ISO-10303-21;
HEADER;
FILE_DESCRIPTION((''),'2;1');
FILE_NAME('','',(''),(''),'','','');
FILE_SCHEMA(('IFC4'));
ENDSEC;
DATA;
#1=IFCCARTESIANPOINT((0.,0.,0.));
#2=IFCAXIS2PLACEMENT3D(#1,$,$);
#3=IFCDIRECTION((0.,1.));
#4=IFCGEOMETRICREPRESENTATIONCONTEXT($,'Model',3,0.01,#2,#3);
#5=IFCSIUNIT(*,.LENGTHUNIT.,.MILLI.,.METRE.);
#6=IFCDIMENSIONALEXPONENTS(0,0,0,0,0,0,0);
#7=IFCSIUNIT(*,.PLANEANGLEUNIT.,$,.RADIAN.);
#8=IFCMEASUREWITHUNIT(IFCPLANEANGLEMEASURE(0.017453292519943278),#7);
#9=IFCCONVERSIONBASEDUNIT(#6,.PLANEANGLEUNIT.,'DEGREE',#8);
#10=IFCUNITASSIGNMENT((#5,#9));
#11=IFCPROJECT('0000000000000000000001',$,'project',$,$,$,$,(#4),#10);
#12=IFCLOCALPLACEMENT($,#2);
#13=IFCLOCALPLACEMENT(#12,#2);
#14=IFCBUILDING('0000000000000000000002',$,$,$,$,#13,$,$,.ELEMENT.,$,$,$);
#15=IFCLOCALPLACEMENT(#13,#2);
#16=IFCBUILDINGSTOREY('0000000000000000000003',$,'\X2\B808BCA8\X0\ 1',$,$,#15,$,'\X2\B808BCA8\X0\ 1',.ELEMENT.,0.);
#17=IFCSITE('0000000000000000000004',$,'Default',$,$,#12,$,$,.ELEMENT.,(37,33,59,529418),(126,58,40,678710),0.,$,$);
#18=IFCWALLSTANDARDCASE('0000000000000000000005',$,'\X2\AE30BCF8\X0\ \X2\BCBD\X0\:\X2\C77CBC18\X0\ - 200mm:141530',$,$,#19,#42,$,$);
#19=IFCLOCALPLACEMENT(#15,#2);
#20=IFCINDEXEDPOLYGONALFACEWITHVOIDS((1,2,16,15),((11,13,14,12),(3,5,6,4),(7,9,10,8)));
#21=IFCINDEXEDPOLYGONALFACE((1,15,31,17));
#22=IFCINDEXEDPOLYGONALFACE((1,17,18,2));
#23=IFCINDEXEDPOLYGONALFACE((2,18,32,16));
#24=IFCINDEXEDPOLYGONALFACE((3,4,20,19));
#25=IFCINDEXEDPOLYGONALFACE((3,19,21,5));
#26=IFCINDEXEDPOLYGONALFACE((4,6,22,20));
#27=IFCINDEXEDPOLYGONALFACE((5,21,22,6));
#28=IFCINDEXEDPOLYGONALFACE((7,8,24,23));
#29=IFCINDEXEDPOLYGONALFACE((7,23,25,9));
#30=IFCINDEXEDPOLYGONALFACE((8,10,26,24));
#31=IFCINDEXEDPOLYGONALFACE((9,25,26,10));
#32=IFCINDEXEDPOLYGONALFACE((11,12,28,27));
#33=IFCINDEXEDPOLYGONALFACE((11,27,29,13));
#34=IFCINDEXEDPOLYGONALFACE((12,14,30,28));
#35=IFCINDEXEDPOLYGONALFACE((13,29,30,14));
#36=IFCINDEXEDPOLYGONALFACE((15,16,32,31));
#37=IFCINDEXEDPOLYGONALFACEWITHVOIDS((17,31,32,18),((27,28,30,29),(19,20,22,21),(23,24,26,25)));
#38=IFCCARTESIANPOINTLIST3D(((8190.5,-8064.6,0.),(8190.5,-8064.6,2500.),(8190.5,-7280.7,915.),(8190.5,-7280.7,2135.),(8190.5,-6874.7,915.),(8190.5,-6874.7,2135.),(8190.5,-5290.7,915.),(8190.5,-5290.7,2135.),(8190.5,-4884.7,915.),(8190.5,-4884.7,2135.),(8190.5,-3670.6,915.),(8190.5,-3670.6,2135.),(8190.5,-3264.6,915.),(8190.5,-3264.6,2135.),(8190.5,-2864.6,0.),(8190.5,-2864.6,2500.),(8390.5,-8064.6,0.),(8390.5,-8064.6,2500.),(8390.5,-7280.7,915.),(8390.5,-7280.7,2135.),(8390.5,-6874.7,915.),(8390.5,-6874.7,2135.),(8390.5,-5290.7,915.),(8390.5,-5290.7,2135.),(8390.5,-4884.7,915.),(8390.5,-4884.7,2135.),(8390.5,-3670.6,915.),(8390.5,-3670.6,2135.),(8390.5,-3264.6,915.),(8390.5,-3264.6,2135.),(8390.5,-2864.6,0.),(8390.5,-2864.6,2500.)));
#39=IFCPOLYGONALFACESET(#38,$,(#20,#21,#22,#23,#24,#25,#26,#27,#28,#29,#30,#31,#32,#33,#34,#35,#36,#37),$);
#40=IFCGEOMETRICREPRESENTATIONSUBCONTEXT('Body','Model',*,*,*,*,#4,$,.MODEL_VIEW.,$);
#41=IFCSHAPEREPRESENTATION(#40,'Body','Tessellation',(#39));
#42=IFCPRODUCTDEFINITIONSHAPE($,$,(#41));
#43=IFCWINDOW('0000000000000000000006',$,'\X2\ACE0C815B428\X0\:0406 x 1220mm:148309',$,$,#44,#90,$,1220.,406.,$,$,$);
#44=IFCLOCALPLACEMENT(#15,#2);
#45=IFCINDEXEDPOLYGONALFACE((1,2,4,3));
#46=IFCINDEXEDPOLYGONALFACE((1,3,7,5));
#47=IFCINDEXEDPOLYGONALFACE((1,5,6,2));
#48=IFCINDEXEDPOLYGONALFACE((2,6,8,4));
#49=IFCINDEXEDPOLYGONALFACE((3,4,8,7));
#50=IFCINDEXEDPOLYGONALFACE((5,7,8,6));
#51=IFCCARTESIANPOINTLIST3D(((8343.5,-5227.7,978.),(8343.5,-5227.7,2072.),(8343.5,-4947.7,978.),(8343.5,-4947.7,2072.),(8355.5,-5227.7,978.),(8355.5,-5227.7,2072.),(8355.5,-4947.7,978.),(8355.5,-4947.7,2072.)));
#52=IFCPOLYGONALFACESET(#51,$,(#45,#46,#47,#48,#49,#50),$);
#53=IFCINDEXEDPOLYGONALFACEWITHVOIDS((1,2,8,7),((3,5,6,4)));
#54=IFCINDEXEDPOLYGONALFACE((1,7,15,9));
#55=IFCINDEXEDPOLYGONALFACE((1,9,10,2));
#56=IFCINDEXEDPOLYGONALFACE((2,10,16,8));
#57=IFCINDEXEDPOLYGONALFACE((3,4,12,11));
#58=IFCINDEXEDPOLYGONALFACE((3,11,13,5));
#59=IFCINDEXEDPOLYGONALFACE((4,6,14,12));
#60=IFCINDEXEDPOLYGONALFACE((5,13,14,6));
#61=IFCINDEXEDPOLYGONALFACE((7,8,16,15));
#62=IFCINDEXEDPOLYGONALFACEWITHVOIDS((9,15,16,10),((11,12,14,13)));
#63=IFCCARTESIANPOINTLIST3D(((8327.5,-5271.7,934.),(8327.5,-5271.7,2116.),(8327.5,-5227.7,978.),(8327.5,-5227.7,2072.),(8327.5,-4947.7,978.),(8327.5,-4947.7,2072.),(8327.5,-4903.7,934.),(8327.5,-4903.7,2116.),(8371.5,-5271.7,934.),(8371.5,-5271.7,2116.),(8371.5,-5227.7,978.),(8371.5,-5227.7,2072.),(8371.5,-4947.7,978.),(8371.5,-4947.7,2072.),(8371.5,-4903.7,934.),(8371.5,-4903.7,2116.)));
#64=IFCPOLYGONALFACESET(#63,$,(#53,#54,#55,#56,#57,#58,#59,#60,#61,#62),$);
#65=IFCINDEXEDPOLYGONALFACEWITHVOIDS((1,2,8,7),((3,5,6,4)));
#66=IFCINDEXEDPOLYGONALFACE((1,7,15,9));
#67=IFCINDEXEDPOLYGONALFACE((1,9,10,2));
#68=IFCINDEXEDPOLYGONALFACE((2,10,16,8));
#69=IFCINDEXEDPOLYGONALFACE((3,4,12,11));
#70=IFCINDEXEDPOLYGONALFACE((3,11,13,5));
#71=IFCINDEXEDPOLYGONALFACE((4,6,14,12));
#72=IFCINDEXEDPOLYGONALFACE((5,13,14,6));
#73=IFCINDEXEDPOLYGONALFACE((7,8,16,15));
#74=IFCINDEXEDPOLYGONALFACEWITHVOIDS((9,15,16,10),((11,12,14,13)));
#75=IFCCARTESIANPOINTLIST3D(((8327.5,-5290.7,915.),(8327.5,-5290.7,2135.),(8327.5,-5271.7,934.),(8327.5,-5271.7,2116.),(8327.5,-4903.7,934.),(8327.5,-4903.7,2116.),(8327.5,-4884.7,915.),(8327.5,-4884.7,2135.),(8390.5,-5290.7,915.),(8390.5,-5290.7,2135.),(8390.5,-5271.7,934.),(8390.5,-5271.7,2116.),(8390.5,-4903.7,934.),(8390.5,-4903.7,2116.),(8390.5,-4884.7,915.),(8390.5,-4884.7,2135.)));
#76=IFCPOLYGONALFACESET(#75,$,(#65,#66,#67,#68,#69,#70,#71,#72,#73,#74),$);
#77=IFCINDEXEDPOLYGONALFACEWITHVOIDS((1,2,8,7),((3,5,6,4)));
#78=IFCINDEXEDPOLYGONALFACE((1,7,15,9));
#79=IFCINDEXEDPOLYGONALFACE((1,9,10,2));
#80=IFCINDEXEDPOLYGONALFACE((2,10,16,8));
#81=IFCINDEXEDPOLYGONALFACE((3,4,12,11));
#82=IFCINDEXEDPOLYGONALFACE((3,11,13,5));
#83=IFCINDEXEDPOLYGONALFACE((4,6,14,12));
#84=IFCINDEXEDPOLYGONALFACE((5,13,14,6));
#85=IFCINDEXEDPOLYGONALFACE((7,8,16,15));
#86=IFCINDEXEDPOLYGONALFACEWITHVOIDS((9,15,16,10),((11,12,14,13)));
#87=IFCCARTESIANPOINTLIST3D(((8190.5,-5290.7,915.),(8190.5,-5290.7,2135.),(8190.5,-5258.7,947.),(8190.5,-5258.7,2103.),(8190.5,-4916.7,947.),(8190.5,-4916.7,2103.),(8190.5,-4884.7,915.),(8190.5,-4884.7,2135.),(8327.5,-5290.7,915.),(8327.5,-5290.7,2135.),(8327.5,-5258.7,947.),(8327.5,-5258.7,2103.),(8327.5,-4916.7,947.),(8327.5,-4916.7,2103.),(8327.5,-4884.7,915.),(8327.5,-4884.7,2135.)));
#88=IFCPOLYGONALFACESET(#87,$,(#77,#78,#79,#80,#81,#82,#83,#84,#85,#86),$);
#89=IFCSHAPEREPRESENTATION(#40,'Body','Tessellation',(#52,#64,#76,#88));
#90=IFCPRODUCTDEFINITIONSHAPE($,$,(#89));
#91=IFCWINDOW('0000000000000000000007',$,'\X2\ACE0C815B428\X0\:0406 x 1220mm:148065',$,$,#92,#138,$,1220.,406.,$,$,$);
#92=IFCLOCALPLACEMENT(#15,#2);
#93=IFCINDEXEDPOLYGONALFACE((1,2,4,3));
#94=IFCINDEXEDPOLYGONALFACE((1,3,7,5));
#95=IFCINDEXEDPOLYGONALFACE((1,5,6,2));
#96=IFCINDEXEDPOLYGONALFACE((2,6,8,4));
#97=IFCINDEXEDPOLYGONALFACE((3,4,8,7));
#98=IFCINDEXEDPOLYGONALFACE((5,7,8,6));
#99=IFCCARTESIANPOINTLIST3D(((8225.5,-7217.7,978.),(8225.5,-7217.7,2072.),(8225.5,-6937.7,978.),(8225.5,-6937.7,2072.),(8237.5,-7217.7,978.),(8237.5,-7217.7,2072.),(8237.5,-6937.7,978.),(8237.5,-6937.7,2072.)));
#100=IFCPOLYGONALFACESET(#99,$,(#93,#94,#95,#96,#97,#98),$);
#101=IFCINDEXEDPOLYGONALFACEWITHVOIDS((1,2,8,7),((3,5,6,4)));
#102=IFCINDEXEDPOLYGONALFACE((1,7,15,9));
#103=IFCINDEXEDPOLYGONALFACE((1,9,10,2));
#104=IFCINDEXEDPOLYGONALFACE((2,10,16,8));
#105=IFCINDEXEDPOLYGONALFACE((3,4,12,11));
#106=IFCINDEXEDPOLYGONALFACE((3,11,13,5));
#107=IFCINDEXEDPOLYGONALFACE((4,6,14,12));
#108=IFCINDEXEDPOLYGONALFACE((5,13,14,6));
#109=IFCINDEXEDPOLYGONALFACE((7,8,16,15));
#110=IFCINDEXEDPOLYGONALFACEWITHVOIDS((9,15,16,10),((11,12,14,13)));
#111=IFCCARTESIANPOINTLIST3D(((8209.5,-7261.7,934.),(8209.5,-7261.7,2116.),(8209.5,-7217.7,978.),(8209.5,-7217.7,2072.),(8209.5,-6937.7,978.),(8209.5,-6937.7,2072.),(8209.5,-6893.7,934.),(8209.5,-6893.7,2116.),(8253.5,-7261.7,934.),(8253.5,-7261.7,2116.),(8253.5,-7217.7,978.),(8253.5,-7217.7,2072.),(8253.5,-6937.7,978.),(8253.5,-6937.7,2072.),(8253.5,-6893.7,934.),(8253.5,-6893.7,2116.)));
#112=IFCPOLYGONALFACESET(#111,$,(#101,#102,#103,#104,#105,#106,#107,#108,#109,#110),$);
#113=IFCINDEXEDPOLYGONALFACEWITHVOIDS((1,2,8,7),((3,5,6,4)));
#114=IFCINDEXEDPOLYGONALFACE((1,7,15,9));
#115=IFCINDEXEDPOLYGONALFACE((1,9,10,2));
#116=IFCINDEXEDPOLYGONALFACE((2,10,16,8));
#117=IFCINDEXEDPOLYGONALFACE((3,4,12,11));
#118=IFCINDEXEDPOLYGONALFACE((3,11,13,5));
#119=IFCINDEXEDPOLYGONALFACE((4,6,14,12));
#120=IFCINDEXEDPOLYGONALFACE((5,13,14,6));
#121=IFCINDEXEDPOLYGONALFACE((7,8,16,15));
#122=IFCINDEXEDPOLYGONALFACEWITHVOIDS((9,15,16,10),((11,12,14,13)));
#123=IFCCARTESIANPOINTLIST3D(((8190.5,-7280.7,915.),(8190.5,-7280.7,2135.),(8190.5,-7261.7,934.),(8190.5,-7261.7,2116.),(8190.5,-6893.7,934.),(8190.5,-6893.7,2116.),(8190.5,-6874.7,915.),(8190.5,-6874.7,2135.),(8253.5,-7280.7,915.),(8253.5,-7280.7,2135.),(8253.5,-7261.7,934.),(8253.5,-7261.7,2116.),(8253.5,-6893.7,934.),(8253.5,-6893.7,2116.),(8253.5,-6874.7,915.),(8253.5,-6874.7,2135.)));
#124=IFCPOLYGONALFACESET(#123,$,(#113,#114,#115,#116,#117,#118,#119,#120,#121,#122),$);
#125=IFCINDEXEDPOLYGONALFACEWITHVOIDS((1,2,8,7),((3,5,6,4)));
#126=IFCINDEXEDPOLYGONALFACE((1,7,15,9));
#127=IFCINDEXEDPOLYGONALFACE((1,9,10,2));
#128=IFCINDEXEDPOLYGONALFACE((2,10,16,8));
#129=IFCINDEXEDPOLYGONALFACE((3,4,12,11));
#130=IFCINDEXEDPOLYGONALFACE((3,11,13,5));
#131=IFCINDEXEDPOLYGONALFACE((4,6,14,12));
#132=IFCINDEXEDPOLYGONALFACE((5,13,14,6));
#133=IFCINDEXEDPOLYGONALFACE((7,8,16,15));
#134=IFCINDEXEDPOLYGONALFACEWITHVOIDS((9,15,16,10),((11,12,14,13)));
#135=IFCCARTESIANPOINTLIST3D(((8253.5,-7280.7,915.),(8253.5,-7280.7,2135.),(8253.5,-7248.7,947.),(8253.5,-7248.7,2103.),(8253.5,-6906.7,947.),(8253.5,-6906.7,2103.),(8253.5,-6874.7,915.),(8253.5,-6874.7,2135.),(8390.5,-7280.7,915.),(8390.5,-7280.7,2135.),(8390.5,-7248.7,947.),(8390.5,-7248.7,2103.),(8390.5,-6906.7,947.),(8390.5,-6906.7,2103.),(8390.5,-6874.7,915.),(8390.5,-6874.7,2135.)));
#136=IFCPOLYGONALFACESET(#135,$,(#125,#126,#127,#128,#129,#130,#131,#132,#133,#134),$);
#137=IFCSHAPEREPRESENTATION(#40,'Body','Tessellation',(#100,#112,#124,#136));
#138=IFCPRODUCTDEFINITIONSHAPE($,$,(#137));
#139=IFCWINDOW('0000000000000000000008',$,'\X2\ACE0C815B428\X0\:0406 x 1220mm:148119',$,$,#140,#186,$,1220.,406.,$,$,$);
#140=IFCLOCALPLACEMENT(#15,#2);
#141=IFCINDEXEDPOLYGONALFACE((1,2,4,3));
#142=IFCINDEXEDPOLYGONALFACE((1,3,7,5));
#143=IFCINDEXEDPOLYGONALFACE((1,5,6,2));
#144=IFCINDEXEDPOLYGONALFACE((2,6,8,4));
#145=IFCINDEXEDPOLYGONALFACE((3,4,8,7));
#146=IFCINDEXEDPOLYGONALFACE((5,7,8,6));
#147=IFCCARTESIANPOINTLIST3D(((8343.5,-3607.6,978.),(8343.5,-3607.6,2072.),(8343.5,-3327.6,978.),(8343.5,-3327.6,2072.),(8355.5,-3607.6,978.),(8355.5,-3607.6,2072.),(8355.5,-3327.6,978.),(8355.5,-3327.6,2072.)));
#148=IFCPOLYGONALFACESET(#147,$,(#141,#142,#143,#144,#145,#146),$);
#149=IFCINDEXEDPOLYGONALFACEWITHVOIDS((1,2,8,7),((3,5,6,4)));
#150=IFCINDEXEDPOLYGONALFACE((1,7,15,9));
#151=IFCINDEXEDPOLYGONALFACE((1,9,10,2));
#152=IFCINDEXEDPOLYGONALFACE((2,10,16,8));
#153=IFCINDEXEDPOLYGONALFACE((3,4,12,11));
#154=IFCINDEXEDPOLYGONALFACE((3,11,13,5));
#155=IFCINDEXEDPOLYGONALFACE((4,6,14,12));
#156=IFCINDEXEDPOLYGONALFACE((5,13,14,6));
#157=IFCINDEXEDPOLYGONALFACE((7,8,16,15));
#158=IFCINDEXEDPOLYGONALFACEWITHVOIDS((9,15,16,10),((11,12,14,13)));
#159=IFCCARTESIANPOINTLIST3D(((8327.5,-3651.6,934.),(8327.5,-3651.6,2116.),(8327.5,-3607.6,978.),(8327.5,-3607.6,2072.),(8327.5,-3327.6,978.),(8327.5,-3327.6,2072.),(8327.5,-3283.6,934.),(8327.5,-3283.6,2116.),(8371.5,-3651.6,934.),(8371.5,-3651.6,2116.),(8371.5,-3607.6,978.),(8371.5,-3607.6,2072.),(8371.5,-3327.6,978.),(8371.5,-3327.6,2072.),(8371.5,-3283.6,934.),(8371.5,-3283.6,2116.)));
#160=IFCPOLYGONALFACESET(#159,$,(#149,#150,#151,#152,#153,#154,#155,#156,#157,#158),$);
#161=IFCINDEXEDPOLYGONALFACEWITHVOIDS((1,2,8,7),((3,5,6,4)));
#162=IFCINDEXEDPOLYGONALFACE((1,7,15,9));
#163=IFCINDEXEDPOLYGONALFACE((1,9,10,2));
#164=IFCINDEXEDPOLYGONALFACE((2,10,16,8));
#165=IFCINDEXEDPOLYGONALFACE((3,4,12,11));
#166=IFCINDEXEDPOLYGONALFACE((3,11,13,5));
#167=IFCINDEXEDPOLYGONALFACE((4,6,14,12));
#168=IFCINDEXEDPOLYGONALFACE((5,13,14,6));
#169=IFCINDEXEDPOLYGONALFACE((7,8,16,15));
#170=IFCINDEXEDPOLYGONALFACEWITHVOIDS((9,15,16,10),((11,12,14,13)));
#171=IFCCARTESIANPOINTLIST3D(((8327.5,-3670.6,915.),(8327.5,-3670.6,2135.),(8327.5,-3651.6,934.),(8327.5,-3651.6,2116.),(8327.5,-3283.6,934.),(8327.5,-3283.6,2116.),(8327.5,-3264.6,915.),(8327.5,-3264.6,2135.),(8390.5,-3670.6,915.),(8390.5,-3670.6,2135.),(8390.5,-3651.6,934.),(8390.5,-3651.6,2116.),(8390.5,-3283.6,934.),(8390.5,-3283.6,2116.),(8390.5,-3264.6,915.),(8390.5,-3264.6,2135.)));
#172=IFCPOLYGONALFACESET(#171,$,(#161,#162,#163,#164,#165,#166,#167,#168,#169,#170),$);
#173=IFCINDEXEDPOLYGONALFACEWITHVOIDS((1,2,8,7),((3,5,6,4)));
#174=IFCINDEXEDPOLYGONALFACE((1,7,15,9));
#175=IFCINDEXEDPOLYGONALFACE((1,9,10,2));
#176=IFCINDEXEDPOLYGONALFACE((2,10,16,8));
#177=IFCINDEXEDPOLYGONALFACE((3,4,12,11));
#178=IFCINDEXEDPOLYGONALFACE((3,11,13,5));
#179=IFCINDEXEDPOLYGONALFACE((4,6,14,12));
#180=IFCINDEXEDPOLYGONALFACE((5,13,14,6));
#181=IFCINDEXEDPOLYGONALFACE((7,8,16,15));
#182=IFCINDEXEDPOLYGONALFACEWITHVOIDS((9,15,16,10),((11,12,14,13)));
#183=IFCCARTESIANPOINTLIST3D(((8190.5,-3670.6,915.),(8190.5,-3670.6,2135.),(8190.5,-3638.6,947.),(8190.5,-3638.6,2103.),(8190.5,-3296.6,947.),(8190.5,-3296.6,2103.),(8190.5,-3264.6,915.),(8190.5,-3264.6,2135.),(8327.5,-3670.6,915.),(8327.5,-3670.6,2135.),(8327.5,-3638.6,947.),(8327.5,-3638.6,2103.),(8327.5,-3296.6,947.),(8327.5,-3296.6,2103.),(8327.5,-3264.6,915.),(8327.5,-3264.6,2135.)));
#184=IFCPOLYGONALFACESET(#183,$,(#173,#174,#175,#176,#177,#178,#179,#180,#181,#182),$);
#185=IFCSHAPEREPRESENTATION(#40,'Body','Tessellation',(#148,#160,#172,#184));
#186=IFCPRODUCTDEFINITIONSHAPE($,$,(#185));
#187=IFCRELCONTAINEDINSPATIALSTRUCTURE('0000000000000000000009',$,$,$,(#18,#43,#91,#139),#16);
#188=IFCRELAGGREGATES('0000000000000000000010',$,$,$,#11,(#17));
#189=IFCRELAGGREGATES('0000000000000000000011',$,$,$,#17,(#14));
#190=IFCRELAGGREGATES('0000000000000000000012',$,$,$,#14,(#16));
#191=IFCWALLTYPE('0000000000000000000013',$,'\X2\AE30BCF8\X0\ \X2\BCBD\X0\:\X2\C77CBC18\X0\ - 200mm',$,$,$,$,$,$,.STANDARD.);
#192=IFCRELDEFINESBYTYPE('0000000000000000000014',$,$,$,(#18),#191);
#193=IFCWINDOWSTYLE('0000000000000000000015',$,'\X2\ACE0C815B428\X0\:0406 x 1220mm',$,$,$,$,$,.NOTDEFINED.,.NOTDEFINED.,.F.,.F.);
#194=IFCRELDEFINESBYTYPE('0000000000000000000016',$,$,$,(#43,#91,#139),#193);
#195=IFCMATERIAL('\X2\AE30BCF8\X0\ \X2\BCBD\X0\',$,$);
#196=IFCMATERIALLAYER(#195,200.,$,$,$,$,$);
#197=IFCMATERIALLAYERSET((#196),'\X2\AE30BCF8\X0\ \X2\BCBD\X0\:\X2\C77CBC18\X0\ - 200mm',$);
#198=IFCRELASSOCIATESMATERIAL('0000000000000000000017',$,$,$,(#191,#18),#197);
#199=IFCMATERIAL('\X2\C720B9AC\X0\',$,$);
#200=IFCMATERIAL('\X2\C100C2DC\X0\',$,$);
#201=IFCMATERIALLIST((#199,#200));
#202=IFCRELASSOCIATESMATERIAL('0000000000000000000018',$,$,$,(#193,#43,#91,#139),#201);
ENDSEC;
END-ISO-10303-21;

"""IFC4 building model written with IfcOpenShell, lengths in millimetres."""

from ifc_helpers import new_model, entity, si_unit, converted_unit, direction, frame, frame_2d, origin, place, context, subcontext, project, spatial, polyline, rectangle, outline, extrude, source, transform, mapped, material, material_list, layer, layer_set, layer_usage, type_object, type_shapes, element, fill, save


model = new_model("IFC4")

# Units and contexts
model_context = context("Model", 3, precision=0.01, world=origin(), true_north=direction((0.0, 1.0)))
body_context = subcontext(model_context, "Body", "Model", "MODEL_VIEW")
ifc_project = project(units=[si_unit("LENGTHUNIT", "METRE", prefix="MILLI"), converted_unit("PLANEANGLEUNIT", "DEGREE", entity("IfcPlaneAngleMeasure", 0.017453292519943278), si_unit("PLANEANGLEUNIT", "RADIAN"), dimensions=[0, 0, 0, 0, 0, 0, 0])], contexts=[model_context])

# Site, building, storey
site_placement = place(None, origin())
site = spatial("IfcSite", under=ifc_project, at=site_placement, Name="Default", CompositionType="ELEMENT", RefLatitude=(37, 33, 59, 529418), RefLongitude=(126, 58, 40, 678710), RefElevation=0.0)
building_placement = place(site_placement, origin())
building = spatial("IfcBuilding", under=site, at=building_placement, CompositionType="ELEMENT")
storey_placement = place(building_placement, origin())
storey = spatial("IfcBuildingStorey", under=building, at=storey_placement, Name="레벨 1", LongName="레벨 1", CompositionType="ELEMENT", Elevation=0.0)

# Wall, openings, windows
ifc_material_1 = material(Name="기본 벽")
ifc_layer = layer(ifc_material_1, 200.0)
ifc_layer_set = layer_set([ifc_layer], Name="기본 벽:일반 - 200mm")
ifc_layer_usage_1 = layer_usage(ifc_layer_set, "AXIS2", "NEGATIVE", 100.0)
wall_type = type_object("IfcWallType", Name="기본 벽:일반 - 200mm", PredefinedType="STANDARD", material=ifc_layer_set)
wall_1_placement = place(storey_placement, frame((8290.5, -2864.6, 0.0), z_axis=(0.0, 0.0, 1.0), x_axis=(0.0, -1.0, 0.0)))
wall_1 = element("IfcWallStandardCase", 1, at=wall_1_placement, inside=storey, type_object=wall_type, material=ifc_layer_usage_1, Name="기본 벽:일반 - 200mm:141530", context=body_context, shape_type="SweptSolid", body=[
    extrude(rectangle(XDim=5200.0, YDim=200.0, at=frame_2d((2600.0, 0.0), x_axis=(-1.0, 0.0))), origin(), (0.0, 0.0, 1.0), 2500.0),
])
opening_1_placement = place(wall_1_placement, frame((2020.1, -100.0, 915.0)))
opening_1 = element("IfcOpeningElement", 2, at=opening_1_placement, cuts=wall_1, ObjectType="Opening", context=body_context, shape_type="SweptSolid", body=[
    extrude(rectangle(XDim=1220.0, YDim=406.0, at=frame_2d((610.0, 203.0), x_axis=(1.0, 0.0))), frame((0.0, 0.0, 0.0), z_axis=(0.0, 1.0, 0.0), x_axis=(0.0, 0.0, 1.0)), (0.0, 0.0, 1.0), 200.0),
])
opening_2_placement = place(wall_1_placement, frame((4416.1, 100.0, 915.0)))
opening_2 = element("IfcOpeningElement", 3, at=opening_2_placement, cuts=wall_1, ObjectType="Opening", context=body_context, shape_type="SweptSolid", body=[
    extrude(rectangle(XDim=1220.0, YDim=406.0, at=frame_2d((610.0, 203.0), x_axis=(1.0, 0.0))), frame((0.0, 0.0, 0.0), z_axis=(0.0, -1.0, 0.0), x_axis=(0.0, 0.0, 1.0)), (0.0, 0.0, 1.0), 200.0),
])
opening_3_placement = place(wall_1_placement, frame((400.0, -100.0, 915.0)))
opening_3 = element("IfcOpeningElement", 4, at=opening_3_placement, cuts=wall_1, ObjectType="Opening", context=body_context, shape_type="SweptSolid", body=[
    extrude(rectangle(XDim=1220.0, YDim=406.0, at=frame_2d((610.0, 203.0), x_axis=(1.0, 0.0))), frame((0.0, 0.0, 0.0), z_axis=(0.0, 1.0, 0.0), x_axis=(0.0, 0.0, 1.0)), (0.0, 0.0, 1.0), 200.0),
])
ifc_material_2 = material(Name="유리")
ifc_material_3 = material(Name="섀시")
ifc_material_list_1 = material_list([ifc_material_2, ifc_material_3])
window_style_1 = type_object("IfcWindowStyle", Name="고정됨:0406 x 1220mm", ConstructionType="NOTDEFINED", OperationType="NOTDEFINED", ParameterTakesPrecedence=False, Sizeable=False, material=ifc_material_list_1)
shared_shape_1 = source(origin(), body_context, "Body", "SweptSolid", [
    extrude(rectangle(XDim=12.0, YDim=280.0, at=frame_2d((0.0, 0.0), x_axis=(1.0, 0.0))), frame((203.0, 159.0, 63.0), z_axis=(0.0, 0.0, 1.0), x_axis=(0.0, -1.0, 0.0)), (0.0, 0.0, 1.0), 1094.0),
    extrude(outline(polyline([(-184.0, -591.0), (184.0, -591.0), (184.0, 591.0), (-184.0, 591.0), (-184.0, -591.0)]), holes=[polyline([(-140.0, -547.0), (-140.0, 547.0), (140.0, 547.0), (140.0, -547.0), (-140.0, -547.0)])]), frame((203.0, 137.0, 610.0), z_axis=(0.0, 1.0, 0.0), x_axis=(1.0, 0.0, 0.0)), (0.0, 0.0, 1.0), 44.0),
    extrude(outline(polyline([(-203.0, -610.0), (203.0, -610.0), (203.0, 610.0), (-203.0, 610.0), (-203.0, -610.0)]), holes=[polyline([(-184.0, -591.0), (-184.0, 591.0), (184.0, 591.0), (184.0, -591.0), (-184.0, -591.0)])]), frame((203.0, 137.0, 610.0), z_axis=(0.0, 1.0, 0.0), x_axis=(1.0, 0.0, 0.0)), (0.0, 0.0, 1.0), 63.0),
    extrude(outline(polyline([(-203.0, -610.0), (203.0, -610.0), (203.0, 610.0), (-203.0, 610.0), (-203.0, -610.0)]), holes=[polyline([(-171.0, -578.0), (-171.0, 578.0), (171.0, 578.0), (171.0, -578.0), (-171.0, -578.0)])]), frame((203.0, 0.0, 610.0), z_axis=(0.0, 1.0, 0.0), x_axis=(1.0, 0.0, 0.0)), (0.0, 0.0, 1.0), 137.0),
])
type_shapes(window_style_1, [shared_shape_1])
window_1_placement = place(opening_1_placement, origin())
window_1 = element("IfcWindow", 5, at=window_1_placement, inside=storey, type_object=window_style_1, material=ifc_material_list_1, Name="고정됨:0406 x 1220mm:148309", OverallHeight=1220.0, OverallWidth=406.0, context=body_context, shape_type="MappedRepresentation", body=[
    mapped(shared_shape_1, transform((0.0, 0.0, 0.0), scale=1.0)),
])
fill(opening_1, window_1)
window_2_placement = place(opening_2_placement, frame((0.0, 0.0, 0.0), z_axis=(0.0, 0.0, 1.0), x_axis=(-1.0, 0.0, 0.0)))
window_2 = element("IfcWindow", 6, at=window_2_placement, inside=storey, type_object=window_style_1, material=ifc_material_list_1, Name="고정됨:0406 x 1220mm:148065", OverallHeight=1220.0, OverallWidth=406.0, context=body_context, shape_type="MappedRepresentation", body=[
    mapped(shared_shape_1, transform((0.0, 0.0, 0.0), scale=1.0)),
])
fill(opening_2, window_2)
window_3_placement = place(opening_3_placement, origin())
window_3 = element("IfcWindow", 7, at=window_3_placement, inside=storey, type_object=window_style_1, material=ifc_material_list_1, Name="고정됨:0406 x 1220mm:148119", OverallHeight=1220.0, OverallWidth=406.0, context=body_context, shape_type="MappedRepresentation", body=[
    mapped(shared_shape_1, transform((0.0, 0.0, 0.0), scale=1.0)),
])
fill(opening_3, window_3)

save(model, "model.ifc")
